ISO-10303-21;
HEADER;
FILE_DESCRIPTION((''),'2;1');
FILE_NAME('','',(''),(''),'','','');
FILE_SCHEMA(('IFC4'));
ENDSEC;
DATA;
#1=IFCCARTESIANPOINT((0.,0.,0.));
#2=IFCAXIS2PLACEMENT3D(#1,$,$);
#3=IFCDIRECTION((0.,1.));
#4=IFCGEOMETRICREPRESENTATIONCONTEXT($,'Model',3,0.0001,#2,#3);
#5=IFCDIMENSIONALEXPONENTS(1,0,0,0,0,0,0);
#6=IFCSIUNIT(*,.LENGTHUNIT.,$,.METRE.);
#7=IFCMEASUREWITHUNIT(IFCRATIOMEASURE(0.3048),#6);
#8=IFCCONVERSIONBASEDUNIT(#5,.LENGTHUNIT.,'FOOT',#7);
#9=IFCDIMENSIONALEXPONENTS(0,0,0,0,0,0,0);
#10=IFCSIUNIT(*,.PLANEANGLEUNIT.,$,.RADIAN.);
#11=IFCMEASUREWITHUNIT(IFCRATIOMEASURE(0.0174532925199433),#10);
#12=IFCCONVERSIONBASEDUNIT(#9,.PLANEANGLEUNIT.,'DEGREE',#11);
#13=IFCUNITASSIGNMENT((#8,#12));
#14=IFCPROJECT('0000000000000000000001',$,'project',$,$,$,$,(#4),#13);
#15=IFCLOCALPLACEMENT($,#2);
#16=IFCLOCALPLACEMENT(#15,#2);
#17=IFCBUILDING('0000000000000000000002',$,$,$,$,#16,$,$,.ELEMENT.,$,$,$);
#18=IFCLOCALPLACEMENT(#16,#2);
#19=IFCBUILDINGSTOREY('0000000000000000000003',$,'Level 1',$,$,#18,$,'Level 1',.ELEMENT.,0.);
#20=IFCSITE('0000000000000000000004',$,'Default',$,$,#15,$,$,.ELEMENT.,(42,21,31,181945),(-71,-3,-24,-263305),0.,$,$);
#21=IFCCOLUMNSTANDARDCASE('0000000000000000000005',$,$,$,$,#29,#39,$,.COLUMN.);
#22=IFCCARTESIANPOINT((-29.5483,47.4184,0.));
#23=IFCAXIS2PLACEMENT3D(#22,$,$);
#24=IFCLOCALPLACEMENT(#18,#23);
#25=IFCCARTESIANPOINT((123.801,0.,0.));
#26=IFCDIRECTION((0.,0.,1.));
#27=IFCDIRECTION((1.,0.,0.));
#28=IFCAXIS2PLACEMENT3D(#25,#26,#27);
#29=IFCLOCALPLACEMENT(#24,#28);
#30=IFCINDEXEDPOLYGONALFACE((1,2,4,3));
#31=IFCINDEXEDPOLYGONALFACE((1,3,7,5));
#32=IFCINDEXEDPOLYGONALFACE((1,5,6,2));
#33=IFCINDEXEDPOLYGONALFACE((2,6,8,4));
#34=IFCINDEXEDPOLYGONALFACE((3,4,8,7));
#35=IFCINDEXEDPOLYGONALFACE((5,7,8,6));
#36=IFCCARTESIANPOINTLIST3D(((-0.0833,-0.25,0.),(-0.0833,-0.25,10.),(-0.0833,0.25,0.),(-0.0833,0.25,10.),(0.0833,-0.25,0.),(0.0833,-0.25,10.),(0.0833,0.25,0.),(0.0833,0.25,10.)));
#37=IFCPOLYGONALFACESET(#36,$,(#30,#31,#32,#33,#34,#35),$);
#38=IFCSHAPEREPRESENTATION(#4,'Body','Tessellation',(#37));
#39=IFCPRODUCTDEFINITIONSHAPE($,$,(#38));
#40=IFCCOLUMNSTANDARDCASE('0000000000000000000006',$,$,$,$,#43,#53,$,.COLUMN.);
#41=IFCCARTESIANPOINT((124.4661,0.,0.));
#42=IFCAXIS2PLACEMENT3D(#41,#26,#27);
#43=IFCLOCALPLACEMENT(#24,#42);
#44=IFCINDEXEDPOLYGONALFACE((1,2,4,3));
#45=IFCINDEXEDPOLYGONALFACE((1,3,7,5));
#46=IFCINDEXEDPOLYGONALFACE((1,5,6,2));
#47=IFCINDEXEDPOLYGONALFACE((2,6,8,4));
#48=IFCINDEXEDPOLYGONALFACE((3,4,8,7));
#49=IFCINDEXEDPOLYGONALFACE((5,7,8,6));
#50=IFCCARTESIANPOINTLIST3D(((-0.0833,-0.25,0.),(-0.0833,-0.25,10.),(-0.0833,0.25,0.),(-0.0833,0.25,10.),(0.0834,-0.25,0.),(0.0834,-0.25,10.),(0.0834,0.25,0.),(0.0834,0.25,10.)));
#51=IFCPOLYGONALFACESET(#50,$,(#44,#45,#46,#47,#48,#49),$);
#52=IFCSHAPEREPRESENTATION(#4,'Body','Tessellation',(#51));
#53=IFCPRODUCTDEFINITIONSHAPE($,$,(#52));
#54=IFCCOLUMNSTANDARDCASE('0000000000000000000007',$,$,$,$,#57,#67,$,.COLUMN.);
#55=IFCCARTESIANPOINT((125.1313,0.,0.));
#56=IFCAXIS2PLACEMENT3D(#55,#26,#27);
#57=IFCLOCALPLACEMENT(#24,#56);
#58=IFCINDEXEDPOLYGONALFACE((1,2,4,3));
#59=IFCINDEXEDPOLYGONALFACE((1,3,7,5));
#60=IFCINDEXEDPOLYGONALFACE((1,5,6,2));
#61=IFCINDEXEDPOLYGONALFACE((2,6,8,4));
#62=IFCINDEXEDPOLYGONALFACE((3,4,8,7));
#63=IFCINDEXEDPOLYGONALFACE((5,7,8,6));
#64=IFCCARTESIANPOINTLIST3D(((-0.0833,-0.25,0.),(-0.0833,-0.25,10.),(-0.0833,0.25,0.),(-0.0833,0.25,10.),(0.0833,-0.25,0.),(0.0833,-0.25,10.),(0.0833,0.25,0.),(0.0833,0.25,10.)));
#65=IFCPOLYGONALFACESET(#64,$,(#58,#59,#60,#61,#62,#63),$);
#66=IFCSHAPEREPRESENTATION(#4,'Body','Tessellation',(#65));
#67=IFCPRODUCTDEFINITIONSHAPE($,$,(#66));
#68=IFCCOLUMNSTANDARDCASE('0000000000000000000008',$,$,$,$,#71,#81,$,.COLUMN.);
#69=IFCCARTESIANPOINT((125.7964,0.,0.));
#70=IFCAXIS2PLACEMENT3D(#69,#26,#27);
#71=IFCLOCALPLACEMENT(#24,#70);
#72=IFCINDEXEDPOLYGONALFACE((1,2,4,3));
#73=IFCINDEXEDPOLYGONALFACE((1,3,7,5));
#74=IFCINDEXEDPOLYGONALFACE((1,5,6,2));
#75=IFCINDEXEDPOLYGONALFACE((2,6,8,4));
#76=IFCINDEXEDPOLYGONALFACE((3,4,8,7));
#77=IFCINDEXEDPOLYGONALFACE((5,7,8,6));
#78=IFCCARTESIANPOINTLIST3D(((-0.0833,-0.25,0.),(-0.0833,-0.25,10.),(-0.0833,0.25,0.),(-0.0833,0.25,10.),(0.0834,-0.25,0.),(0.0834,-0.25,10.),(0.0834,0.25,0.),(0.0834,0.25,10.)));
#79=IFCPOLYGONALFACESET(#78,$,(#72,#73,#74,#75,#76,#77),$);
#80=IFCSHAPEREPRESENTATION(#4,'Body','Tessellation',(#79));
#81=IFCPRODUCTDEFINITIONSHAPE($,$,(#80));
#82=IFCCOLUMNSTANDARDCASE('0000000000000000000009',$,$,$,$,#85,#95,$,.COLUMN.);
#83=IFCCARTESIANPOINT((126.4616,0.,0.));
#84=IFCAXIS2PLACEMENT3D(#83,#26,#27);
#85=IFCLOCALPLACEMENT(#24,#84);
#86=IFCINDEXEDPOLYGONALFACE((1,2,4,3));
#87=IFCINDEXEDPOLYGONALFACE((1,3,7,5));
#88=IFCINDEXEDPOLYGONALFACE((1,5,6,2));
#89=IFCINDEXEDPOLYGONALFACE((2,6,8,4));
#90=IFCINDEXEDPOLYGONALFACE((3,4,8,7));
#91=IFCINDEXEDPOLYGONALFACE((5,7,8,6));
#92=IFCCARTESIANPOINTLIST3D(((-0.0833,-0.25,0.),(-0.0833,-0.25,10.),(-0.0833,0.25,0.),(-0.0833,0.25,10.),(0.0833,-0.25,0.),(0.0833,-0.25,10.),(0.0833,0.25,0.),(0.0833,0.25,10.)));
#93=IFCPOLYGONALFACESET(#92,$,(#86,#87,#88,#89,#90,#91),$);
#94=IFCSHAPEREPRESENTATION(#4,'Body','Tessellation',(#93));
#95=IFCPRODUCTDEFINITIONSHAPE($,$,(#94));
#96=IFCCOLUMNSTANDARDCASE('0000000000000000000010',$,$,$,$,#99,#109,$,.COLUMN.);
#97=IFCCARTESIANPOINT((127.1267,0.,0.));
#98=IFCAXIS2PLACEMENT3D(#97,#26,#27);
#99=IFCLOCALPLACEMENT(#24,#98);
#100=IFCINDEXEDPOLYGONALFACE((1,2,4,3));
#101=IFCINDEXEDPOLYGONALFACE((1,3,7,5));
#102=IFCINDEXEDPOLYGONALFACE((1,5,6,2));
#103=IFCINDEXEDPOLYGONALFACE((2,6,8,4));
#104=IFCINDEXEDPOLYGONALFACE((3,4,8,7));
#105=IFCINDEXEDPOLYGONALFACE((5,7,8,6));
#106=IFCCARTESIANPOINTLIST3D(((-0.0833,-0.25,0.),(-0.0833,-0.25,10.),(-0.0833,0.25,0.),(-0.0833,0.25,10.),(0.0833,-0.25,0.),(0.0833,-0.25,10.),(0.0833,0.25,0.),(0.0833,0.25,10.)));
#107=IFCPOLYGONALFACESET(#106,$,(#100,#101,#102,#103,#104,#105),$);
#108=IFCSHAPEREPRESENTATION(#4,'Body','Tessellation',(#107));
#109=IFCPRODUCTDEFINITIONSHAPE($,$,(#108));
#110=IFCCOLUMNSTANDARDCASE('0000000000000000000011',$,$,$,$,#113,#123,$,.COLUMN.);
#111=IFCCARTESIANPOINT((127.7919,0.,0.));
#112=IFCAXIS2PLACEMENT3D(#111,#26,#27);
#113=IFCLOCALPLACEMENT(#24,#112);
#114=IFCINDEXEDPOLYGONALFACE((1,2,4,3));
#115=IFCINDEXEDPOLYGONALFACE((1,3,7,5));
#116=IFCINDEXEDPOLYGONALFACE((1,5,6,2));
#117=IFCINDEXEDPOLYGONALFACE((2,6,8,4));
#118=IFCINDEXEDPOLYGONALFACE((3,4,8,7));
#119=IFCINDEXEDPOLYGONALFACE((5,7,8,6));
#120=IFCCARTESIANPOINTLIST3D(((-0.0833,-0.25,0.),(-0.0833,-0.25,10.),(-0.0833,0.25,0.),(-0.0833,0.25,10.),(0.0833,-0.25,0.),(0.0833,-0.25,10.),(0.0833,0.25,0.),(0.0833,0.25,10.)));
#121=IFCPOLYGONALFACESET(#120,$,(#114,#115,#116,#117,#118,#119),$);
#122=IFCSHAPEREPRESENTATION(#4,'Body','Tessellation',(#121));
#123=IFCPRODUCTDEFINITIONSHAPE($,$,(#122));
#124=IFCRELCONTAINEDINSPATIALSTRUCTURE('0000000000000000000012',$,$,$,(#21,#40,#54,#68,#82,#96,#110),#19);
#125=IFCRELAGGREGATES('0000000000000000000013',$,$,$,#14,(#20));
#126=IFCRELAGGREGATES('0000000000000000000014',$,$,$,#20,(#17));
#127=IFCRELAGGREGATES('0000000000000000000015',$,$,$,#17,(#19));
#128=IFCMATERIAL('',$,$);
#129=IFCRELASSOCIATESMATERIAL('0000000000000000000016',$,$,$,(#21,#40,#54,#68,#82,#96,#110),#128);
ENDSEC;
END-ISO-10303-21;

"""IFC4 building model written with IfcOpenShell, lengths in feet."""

from ifc_helpers import new_model, entity, si_unit, converted_unit, direction, frame, origin, place, context, project, spatial, rectangle, extrude, material, element, save


model = new_model("IFC4")

# Units and contexts
model_context = context("Model", 3, precision=0.0001, world=origin(), true_north=direction((0.0, 1.0)))
ifc_project = project(units=[converted_unit("LENGTHUNIT", "FOOT", entity("IfcRatioMeasure", 0.3048), si_unit("LENGTHUNIT", "METRE"), dimensions=[1, 0, 0, 0, 0, 0, 0]), converted_unit("PLANEANGLEUNIT", "DEGREE", entity("IfcRatioMeasure", 0.0174532925199433), si_unit("PLANEANGLEUNIT", "RADIAN"), dimensions=[0, 0, 0, 0, 0, 0, 0])], contexts=[model_context])

# Site, building, storey
site_placement = place(None, origin())
site = spatial("IfcSite", under=ifc_project, at=site_placement, Name="Default", CompositionType="ELEMENT", RefLatitude=(42, 21, 31, 181945), RefLongitude=(-71, -3, -24, -263305), RefElevation=0.0)
building_placement = place(site_placement, origin())
building = spatial("IfcBuilding", under=site, at=building_placement, CompositionType="ELEMENT")
storey_placement = place(building_placement, origin())
storey = spatial("IfcBuildingStorey", under=building, at=storey_placement, Name="Level 1", LongName="Level 1", CompositionType="ELEMENT", Elevation=0.0)

# Columns
ifc_material = material(Name="")
placement_1 = place(storey_placement, frame((-29.5483, 47.4184, 0.0)))
for number, where, z_axis, x_axis in (
    (1, (123.801, 0.0, 0.0), (0.0, 0.0, 1.0), (1.0, 0.0, 0.0)),
    (2, (124.4661, 0.0, 0.0), (0.0, 0.0, 1.0), (1.0, 0.0, 0.0)),
    (3, (125.1313, 0.0, 0.0), (0.0, 0.0, 1.0), (1.0, 0.0, 0.0)),
    (4, (125.7964, 0.0, 0.0), (0.0, 0.0, 1.0), (1.0, 0.0, 0.0)),
    (5, (126.4616, 0.0, 0.0), (0.0, 0.0, 1.0), (1.0, 0.0, 0.0)),
    (6, (127.1267, 0.0, 0.0), (0.0, 0.0, 1.0), (1.0, 0.0, 0.0)),
    (7, (127.7919, 0.0, 0.0), (0.0, 0.0, 1.0), (1.0, 0.0, 0.0)),
):
    element("IfcColumnStandardCase", number, at=place(placement_1, frame(where, z_axis=z_axis, x_axis=x_axis)), inside=storey, material=ifc_material, PredefinedType="COLUMN", context=model_context, shape_type="SweptSolid", body=[
        extrude(rectangle(XDim=0.1667, YDim=0.5), origin(), (0.0, 0.0, 1.0), 10.0),
    ])

save(model, "model.ifc")
